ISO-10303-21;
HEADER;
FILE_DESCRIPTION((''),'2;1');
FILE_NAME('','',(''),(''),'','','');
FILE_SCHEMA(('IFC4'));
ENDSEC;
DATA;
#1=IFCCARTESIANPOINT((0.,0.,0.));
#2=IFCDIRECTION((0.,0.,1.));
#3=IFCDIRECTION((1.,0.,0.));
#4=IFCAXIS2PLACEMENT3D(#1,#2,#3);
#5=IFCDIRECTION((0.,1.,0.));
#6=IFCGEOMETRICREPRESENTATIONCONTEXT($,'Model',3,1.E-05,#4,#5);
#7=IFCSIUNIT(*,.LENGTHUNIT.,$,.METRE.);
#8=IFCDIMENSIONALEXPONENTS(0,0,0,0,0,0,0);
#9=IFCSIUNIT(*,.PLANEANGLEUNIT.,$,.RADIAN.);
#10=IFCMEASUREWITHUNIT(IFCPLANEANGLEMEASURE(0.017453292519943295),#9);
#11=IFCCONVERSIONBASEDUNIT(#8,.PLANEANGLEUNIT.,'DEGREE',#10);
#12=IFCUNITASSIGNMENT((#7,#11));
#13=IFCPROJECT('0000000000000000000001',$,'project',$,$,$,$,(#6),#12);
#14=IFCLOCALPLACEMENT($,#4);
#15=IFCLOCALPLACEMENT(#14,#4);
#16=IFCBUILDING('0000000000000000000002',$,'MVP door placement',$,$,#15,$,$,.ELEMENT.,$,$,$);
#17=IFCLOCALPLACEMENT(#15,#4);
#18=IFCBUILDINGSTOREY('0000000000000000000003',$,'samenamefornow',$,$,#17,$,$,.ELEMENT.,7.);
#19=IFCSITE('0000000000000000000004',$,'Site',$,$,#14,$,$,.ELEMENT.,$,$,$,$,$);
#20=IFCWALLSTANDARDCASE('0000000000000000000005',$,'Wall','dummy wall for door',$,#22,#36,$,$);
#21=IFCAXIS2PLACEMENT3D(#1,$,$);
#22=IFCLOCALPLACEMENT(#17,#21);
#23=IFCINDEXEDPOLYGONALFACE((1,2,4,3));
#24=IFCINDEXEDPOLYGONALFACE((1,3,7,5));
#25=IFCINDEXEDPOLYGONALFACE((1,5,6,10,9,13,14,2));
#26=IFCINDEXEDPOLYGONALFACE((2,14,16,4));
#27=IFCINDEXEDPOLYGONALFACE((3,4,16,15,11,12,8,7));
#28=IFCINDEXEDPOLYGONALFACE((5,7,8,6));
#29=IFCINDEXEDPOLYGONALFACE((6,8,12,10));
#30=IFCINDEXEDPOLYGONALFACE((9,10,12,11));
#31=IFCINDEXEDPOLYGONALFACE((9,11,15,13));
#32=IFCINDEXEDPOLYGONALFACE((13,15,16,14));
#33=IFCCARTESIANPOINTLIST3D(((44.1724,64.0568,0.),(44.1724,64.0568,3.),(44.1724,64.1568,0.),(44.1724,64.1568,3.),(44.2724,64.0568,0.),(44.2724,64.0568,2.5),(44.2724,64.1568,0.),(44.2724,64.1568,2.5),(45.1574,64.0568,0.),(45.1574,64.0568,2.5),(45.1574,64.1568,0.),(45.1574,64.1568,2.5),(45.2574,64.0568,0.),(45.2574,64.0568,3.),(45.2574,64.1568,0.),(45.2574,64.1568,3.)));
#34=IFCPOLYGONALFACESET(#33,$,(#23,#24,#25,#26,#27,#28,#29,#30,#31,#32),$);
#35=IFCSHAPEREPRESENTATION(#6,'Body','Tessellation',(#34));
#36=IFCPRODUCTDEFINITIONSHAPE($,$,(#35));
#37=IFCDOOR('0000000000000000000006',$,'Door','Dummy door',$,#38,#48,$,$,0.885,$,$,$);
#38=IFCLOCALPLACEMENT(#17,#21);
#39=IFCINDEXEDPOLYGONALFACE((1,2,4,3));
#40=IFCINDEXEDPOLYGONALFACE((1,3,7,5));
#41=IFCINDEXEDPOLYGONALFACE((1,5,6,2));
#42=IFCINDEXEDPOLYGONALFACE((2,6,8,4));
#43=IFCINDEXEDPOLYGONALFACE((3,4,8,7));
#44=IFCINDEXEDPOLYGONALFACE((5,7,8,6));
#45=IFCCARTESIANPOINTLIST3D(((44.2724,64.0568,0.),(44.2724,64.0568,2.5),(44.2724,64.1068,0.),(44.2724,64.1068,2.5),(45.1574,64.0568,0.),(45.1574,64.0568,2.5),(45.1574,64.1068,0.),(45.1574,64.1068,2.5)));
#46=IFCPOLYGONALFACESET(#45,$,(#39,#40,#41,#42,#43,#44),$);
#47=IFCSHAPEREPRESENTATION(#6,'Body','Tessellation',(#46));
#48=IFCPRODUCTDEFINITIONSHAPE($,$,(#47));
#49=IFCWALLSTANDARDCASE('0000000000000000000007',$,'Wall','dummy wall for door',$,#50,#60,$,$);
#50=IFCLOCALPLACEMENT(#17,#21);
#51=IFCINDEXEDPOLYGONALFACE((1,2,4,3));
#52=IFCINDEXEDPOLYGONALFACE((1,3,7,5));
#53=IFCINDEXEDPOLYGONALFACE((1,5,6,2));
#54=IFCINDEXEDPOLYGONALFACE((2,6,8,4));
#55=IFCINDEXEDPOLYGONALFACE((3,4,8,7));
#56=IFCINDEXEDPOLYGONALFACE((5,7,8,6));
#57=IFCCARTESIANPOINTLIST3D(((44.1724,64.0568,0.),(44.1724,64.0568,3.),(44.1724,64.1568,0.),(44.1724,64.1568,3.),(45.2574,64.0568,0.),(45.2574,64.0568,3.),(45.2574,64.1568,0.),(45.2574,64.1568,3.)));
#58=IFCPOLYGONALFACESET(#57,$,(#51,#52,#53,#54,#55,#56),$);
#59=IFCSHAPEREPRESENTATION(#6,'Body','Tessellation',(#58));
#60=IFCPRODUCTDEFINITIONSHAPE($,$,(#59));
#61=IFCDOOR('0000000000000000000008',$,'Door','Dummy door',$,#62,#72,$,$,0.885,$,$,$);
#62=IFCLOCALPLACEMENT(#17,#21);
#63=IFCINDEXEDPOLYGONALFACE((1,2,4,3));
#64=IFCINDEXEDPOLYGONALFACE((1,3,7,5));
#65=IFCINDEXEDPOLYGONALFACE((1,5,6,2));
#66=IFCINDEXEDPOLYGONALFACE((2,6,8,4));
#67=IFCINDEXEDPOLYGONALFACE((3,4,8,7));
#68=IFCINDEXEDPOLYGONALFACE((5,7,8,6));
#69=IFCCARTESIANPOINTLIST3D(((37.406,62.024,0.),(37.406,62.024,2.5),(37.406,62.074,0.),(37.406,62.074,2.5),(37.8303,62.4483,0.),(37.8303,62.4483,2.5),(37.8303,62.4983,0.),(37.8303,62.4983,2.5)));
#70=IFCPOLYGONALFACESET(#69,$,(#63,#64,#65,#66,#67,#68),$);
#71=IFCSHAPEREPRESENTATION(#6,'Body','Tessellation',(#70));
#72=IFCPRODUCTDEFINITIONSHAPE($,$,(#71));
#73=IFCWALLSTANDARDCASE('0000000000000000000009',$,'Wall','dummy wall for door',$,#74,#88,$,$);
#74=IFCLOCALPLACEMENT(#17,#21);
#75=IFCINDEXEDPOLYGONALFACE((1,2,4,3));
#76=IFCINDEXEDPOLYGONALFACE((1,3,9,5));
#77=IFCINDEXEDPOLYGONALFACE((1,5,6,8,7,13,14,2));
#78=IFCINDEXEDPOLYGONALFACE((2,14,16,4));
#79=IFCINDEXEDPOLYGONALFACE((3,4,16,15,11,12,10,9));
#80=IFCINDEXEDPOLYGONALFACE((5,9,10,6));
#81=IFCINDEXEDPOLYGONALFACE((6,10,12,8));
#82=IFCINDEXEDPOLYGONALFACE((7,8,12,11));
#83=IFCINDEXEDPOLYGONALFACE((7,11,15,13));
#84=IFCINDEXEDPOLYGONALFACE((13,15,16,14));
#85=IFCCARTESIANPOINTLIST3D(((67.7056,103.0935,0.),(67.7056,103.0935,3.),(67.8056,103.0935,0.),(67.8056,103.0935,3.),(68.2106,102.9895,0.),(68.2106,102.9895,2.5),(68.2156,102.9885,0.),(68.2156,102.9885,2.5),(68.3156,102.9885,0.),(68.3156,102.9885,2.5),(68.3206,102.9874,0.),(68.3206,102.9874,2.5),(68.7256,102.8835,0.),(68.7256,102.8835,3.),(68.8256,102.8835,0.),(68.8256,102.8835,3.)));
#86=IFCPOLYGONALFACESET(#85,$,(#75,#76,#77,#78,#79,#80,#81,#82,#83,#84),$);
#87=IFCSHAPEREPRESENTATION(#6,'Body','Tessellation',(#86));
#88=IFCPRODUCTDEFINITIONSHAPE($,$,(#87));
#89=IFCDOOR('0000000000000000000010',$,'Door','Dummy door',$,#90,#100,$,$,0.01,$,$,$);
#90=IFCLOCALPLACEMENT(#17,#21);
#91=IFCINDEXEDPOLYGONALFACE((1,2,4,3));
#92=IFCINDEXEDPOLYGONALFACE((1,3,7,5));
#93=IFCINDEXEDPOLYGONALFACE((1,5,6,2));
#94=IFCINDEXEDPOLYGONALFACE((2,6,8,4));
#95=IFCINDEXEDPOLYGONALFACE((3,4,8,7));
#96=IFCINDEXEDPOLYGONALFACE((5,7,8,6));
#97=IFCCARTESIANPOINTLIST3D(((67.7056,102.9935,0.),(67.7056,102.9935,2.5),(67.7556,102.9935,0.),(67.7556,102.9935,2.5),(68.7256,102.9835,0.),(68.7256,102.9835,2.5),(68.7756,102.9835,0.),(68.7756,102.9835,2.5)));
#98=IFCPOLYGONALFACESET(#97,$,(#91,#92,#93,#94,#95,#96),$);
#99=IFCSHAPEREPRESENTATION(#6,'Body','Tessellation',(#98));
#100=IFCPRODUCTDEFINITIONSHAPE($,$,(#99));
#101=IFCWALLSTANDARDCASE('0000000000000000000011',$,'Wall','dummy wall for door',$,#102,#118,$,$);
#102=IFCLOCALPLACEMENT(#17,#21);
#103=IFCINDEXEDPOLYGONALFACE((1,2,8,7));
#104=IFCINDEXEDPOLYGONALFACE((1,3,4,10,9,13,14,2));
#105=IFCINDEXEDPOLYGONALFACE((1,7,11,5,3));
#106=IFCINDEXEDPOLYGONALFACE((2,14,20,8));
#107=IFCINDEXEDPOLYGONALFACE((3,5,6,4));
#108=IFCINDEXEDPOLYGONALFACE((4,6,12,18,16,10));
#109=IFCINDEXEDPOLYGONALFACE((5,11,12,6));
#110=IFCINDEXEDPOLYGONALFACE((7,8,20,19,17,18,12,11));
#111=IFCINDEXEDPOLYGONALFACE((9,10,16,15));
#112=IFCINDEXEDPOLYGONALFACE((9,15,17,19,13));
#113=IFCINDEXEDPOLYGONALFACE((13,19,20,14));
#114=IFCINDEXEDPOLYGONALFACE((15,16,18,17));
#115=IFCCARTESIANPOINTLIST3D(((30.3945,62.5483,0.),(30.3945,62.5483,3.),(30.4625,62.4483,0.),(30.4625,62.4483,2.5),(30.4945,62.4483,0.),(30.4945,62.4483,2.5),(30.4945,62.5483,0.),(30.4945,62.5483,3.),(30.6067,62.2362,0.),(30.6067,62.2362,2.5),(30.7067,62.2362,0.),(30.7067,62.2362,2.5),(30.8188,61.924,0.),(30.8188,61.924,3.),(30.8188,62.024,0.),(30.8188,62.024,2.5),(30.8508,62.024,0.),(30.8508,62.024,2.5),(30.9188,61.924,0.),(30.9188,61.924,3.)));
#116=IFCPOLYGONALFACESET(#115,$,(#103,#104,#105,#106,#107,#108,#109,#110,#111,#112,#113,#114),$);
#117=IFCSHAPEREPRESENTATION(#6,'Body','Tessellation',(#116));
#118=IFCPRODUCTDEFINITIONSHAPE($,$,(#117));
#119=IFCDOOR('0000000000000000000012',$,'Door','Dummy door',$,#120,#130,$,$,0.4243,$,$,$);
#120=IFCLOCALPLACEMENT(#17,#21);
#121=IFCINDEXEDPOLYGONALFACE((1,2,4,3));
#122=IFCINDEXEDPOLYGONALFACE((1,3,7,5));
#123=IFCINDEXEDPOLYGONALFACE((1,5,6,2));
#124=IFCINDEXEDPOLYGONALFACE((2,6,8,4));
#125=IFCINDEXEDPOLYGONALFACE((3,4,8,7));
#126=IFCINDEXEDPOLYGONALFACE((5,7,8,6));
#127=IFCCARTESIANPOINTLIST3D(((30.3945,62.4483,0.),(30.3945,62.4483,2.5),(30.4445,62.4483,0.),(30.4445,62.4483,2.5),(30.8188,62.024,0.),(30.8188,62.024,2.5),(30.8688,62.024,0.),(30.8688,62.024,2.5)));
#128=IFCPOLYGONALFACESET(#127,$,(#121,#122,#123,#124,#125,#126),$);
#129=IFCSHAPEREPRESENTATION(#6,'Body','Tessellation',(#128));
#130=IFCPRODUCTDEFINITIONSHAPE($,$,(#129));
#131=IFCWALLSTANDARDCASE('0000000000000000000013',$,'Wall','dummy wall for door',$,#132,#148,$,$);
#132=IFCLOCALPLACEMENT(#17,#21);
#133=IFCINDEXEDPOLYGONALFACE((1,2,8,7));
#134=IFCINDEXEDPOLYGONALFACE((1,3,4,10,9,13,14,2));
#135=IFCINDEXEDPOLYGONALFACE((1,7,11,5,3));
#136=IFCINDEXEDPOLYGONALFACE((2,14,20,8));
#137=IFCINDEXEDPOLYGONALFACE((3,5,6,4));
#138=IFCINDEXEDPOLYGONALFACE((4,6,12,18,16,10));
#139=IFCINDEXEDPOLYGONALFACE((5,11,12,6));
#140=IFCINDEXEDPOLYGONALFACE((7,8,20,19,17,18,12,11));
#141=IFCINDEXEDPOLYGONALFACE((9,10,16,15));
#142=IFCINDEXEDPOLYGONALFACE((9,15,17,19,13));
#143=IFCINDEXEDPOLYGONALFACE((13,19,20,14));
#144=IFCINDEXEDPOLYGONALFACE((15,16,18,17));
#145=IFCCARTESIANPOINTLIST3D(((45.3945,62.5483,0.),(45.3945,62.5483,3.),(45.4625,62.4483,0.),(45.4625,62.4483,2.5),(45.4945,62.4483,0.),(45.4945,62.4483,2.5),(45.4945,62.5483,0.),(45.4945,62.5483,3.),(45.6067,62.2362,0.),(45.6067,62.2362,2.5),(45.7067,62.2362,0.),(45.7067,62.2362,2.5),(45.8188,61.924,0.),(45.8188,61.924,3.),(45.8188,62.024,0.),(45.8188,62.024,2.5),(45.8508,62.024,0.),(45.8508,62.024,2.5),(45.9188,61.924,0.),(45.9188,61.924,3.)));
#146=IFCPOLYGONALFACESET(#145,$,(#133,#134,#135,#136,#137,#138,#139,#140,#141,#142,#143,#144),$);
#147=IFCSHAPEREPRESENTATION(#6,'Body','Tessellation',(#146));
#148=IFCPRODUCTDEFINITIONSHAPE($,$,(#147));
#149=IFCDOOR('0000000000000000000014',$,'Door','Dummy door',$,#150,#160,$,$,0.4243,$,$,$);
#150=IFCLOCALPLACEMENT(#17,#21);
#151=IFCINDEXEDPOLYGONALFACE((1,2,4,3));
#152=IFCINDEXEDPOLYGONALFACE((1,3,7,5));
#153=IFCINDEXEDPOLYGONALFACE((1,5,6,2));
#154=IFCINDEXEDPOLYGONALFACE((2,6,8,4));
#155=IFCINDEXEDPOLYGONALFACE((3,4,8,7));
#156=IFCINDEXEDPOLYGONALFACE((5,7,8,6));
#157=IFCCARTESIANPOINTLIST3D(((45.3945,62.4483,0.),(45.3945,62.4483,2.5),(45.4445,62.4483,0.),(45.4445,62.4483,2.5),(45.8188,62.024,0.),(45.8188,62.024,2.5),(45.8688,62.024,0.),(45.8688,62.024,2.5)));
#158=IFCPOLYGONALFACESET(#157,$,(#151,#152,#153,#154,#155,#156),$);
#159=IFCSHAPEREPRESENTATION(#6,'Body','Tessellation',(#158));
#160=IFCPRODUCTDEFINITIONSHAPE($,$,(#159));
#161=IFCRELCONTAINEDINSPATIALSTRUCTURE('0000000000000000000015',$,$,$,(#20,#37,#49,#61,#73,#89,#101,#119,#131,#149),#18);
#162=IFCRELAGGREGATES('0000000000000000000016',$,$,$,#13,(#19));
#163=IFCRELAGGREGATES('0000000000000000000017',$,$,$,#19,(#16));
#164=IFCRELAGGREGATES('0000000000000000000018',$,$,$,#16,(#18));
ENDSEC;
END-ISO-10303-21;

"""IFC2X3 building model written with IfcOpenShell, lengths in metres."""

from ifc_helpers import new_model, entity, si_unit, converted_unit, direction, origin_with_axes, place, context, project, spatial, polyline, outline, extrude, element, fill, save


model = new_model("IFC2X3")

# Units and contexts
model_context = context("Model", 3, precision=1e-05, world=origin_with_axes(), true_north=direction((0.0, 1.0, 0.0)))
ifc_project = project(units=[si_unit("LENGTHUNIT", "METRE"), converted_unit("PLANEANGLEUNIT", "DEGREE", entity("IfcPlaneAngleMeasure", 0.017453292519943295), si_unit("PLANEANGLEUNIT", "RADIAN"), dimensions=[0, 0, 0, 0, 0, 0, 0])], contexts=[model_context])

# Site, building, storey
site_placement = place(None, origin_with_axes())
site = spatial("IfcSite", under=ifc_project, at=site_placement, Name="Site", CompositionType="ELEMENT")
building_placement = place(site_placement, origin_with_axes())
building = spatial("IfcBuilding", under=site, at=building_placement, Name="MVP door placement", CompositionType="ELEMENT")
storey_placement = place(building_placement, origin_with_axes())
storey = spatial("IfcBuildingStorey", under=building, at=storey_placement, Name="samenamefornow", CompositionType="ELEMENT", Elevation=7.0)

# Walls, openings, doors
wall_1_placement = place(storey_placement, origin_with_axes())
wall_1 = element("IfcWallStandardCase", 1, at=wall_1_placement, inside=storey, Name="Wall", Description="dummy wall for door", context=model_context, shape_type="SweptSolid", body=[
    extrude(outline(polyline([(45.2574, 64.0568, 0.0), (44.1724, 64.0568, 0.0), (44.1724, 64.1568, 0.0), (45.2574, 64.1568, 0.0), (45.2574, 64.0568, 0.0)])), origin_with_axes(), (0.0, 0.0, 1.0), 3.0),
])
opening_1_placement = place(wall_1_placement, origin_with_axes())
opening_1 = element("IfcOpeningElement", 2, at=opening_1_placement, cuts=wall_1, context=model_context, shape_type="SweptSolid", body=[
    extrude(outline(polyline([(45.1574, 64.0568, 0.0), (44.2724, 64.0568, 0.0), (44.2724, 64.1568, 0.0), (45.1574, 64.1568, 0.0), (45.1574, 64.0568, 0.0)])), origin_with_axes(), (0.0, 0.0, 1.0), 2.5),
])
door_1_placement = place(opening_1_placement, origin_with_axes())
door_1 = element("IfcDoor", 3, at=door_1_placement, inside=storey, Name="Door", Description="Dummy door", OverallWidth=0.885, context=model_context, shape_type="SweptSolid", body=[
    extrude(outline(polyline([(45.1574, 64.0568, 0.0), (44.2724, 64.0568, 0.0), (44.2724, 64.1068, 0.0), (45.1574, 64.1068, 0.0), (45.1574, 64.0568, 0.0)])), origin_with_axes(), (0.0, 0.0, 1.0), 2.5),
])
fill(opening_1, door_1)
wall_2_placement = place(storey_placement, origin_with_axes())
wall_2 = element("IfcWallStandardCase", 4, at=wall_2_placement, inside=storey, Name="Wall", Description="dummy wall for door", context=model_context, shape_type="SweptSolid", body=[
    extrude(outline(polyline([(45.2574, 64.0568, 0.0), (44.1724, 64.0568, 0.0), (44.1724, 64.1568, 0.0), (45.2574, 64.1568, 0.0), (45.2574, 64.0568, 0.0)])), origin_with_axes(), (0.0, 0.0, 1.0), 3.0),
])
opening_2_placement = place(wall_2_placement, origin_with_axes())
opening_2 = element("IfcOpeningElement", 5, at=opening_2_placement, cuts=wall_2, context=model_context, shape_type="SweptSolid", body=[
    extrude(outline(polyline([(37.406, 62.024, 0.0), (37.8303, 62.4483, 0.0), (37.8303, 62.5483, 0.0), (37.406, 62.124, 0.0), (37.406, 62.024, 0.0)])), origin_with_axes(), (0.0, 0.0, 1.0), 2.5),
])
door_2_placement = place(opening_2_placement, origin_with_axes())
door_2 = element("IfcDoor", 6, at=door_2_placement, inside=storey, Name="Door", Description="Dummy door", OverallWidth=0.885, context=model_context, shape_type="SweptSolid", body=[
    extrude(outline(polyline([(37.406, 62.024, 0.0), (37.8303, 62.4483, 0.0), (37.8303, 62.4983, 0.0), (37.406, 62.074, 0.0), (37.406, 62.024, 0.0)])), origin_with_axes(), (0.0, 0.0, 1.0), 2.5),
])
fill(opening_2, door_2)
wall_3_placement = place(storey_placement, origin_with_axes())
wall_3 = element("IfcWallStandardCase", 7, at=wall_3_placement, inside=storey, Name="Wall", Description="dummy wall for door", context=model_context, shape_type="SweptSolid", body=[
    extrude(outline(polyline([(68.7256, 102.8835, 0.0), (67.7056, 103.0935, 0.0), (67.8056, 103.0935, 0.0), (68.8256, 102.8835, 0.0), (68.7256, 102.8835, 0.0)])), origin_with_axes(), (0.0, 0.0, 1.0), 3.0),
])
opening_3_placement = place(wall_3_placement, origin_with_axes())
opening_3 = element("IfcOpeningElement", 8, at=opening_3_placement, cuts=wall_3, context=model_context, shape_type="SweptSolid", body=[
    extrude(outline(polyline([(68.7256, 102.9835, 0.0), (67.7056, 102.9935, 0.0), (67.8056, 102.9935, 0.0), (68.8256, 102.9835, 0.0), (68.7256, 102.9835, 0.0)])), origin_with_axes(), (0.0, 0.0, 1.0), 2.5),
])
door_3_placement = place(opening_3_placement, origin_with_axes())
door_3 = element("IfcDoor", 9, at=door_3_placement, inside=storey, Name="Door", Description="Dummy door", OverallWidth=0.01, context=model_context, shape_type="SweptSolid", body=[
    extrude(outline(polyline([(68.7256, 102.9835, 0.0), (67.7056, 102.9935, 0.0), (67.7556, 102.9935, 0.0), (68.7756, 102.9835, 0.0), (68.7256, 102.9835, 0.0)])), origin_with_axes(), (0.0, 0.0, 1.0), 2.5),
])
fill(opening_3, door_3)
wall_4_placement = place(storey_placement, origin_with_axes())
wall_4 = element("IfcWallStandardCase", 10, at=wall_4_placement, inside=storey, Name="Wall", Description="dummy wall for door", context=model_context, shape_type="SweptSolid", body=[
    extrude(outline(polyline([(30.8188, 61.924, 0.0), (30.3945, 62.5483, 0.0), (30.4945, 62.5483, 0.0), (30.9188, 61.924, 0.0), (30.8188, 61.924, 0.0)])), origin_with_axes(), (0.0, 0.0, 1.0), 3.0),
])
opening_4_placement = place(wall_4_placement, origin_with_axes())
opening_4 = element("IfcOpeningElement", 11, at=opening_4_placement, cuts=wall_4, context=model_context, shape_type="SweptSolid", body=[
    extrude(outline(polyline([(30.8188, 62.024, 0.0), (30.3945, 62.4483, 0.0), (30.4945, 62.4483, 0.0), (30.9188, 62.024, 0.0), (30.8188, 62.024, 0.0)])), origin_with_axes(), (0.0, 0.0, 1.0), 2.5),
])
door_4_placement = place(opening_4_placement, origin_with_axes())
door_4 = element("IfcDoor", 12, at=door_4_placement, inside=storey, Name="Door", Description="Dummy door", OverallWidth=0.4243, context=model_context, shape_type="SweptSolid", body=[
    extrude(outline(polyline([(30.8188, 62.024, 0.0), (30.3945, 62.4483, 0.0), (30.4445, 62.4483, 0.0), (30.8688, 62.024, 0.0), (30.8188, 62.024, 0.0)])), origin_with_axes(), (0.0, 0.0, 1.0), 2.5),
])
fill(opening_4, door_4)
wall_5_placement = place(storey_placement, origin_with_axes())
wall_5 = element("IfcWallStandardCase", 13, at=wall_5_placement, inside=storey, Name="Wall", Description="dummy wall for door", context=model_context, shape_type="SweptSolid", body=[
    extrude(outline(polyline([(45.8188, 61.924, 0.0), (45.3945, 62.5483, 0.0), (45.4945, 62.5483, 0.0), (45.9188, 61.924, 0.0), (45.8188, 61.924, 0.0)])), origin_with_axes(), (0.0, 0.0, 1.0), 3.0),
])
opening_5_placement = place(wall_5_placement, origin_with_axes())
opening_5 = element("IfcOpeningElement", 14, at=opening_5_placement, cuts=wall_5, context=model_context, shape_type="SweptSolid", body=[
    extrude(outline(polyline([(45.8188, 62.024, 0.0), (45.3945, 62.4483, 0.0), (45.4945, 62.4483, 0.0), (45.9188, 62.024, 0.0), (45.8188, 62.024, 0.0)])), origin_with_axes(), (0.0, 0.0, 1.0), 2.5),
])
door_5_placement = place(opening_5_placement, origin_with_axes())
door_5 = element("IfcDoor", 15, at=door_5_placement, inside=storey, Name="Door", Description="Dummy door", OverallWidth=0.4243, context=model_context, shape_type="SweptSolid", body=[
    extrude(outline(polyline([(45.8188, 62.024, 0.0), (45.3945, 62.4483, 0.0), (45.4445, 62.4483, 0.0), (45.8688, 62.024, 0.0), (45.8188, 62.024, 0.0)])), origin_with_axes(), (0.0, 0.0, 1.0), 2.5),
])
fill(opening_5, door_5)

save(model, "model.ifc")
